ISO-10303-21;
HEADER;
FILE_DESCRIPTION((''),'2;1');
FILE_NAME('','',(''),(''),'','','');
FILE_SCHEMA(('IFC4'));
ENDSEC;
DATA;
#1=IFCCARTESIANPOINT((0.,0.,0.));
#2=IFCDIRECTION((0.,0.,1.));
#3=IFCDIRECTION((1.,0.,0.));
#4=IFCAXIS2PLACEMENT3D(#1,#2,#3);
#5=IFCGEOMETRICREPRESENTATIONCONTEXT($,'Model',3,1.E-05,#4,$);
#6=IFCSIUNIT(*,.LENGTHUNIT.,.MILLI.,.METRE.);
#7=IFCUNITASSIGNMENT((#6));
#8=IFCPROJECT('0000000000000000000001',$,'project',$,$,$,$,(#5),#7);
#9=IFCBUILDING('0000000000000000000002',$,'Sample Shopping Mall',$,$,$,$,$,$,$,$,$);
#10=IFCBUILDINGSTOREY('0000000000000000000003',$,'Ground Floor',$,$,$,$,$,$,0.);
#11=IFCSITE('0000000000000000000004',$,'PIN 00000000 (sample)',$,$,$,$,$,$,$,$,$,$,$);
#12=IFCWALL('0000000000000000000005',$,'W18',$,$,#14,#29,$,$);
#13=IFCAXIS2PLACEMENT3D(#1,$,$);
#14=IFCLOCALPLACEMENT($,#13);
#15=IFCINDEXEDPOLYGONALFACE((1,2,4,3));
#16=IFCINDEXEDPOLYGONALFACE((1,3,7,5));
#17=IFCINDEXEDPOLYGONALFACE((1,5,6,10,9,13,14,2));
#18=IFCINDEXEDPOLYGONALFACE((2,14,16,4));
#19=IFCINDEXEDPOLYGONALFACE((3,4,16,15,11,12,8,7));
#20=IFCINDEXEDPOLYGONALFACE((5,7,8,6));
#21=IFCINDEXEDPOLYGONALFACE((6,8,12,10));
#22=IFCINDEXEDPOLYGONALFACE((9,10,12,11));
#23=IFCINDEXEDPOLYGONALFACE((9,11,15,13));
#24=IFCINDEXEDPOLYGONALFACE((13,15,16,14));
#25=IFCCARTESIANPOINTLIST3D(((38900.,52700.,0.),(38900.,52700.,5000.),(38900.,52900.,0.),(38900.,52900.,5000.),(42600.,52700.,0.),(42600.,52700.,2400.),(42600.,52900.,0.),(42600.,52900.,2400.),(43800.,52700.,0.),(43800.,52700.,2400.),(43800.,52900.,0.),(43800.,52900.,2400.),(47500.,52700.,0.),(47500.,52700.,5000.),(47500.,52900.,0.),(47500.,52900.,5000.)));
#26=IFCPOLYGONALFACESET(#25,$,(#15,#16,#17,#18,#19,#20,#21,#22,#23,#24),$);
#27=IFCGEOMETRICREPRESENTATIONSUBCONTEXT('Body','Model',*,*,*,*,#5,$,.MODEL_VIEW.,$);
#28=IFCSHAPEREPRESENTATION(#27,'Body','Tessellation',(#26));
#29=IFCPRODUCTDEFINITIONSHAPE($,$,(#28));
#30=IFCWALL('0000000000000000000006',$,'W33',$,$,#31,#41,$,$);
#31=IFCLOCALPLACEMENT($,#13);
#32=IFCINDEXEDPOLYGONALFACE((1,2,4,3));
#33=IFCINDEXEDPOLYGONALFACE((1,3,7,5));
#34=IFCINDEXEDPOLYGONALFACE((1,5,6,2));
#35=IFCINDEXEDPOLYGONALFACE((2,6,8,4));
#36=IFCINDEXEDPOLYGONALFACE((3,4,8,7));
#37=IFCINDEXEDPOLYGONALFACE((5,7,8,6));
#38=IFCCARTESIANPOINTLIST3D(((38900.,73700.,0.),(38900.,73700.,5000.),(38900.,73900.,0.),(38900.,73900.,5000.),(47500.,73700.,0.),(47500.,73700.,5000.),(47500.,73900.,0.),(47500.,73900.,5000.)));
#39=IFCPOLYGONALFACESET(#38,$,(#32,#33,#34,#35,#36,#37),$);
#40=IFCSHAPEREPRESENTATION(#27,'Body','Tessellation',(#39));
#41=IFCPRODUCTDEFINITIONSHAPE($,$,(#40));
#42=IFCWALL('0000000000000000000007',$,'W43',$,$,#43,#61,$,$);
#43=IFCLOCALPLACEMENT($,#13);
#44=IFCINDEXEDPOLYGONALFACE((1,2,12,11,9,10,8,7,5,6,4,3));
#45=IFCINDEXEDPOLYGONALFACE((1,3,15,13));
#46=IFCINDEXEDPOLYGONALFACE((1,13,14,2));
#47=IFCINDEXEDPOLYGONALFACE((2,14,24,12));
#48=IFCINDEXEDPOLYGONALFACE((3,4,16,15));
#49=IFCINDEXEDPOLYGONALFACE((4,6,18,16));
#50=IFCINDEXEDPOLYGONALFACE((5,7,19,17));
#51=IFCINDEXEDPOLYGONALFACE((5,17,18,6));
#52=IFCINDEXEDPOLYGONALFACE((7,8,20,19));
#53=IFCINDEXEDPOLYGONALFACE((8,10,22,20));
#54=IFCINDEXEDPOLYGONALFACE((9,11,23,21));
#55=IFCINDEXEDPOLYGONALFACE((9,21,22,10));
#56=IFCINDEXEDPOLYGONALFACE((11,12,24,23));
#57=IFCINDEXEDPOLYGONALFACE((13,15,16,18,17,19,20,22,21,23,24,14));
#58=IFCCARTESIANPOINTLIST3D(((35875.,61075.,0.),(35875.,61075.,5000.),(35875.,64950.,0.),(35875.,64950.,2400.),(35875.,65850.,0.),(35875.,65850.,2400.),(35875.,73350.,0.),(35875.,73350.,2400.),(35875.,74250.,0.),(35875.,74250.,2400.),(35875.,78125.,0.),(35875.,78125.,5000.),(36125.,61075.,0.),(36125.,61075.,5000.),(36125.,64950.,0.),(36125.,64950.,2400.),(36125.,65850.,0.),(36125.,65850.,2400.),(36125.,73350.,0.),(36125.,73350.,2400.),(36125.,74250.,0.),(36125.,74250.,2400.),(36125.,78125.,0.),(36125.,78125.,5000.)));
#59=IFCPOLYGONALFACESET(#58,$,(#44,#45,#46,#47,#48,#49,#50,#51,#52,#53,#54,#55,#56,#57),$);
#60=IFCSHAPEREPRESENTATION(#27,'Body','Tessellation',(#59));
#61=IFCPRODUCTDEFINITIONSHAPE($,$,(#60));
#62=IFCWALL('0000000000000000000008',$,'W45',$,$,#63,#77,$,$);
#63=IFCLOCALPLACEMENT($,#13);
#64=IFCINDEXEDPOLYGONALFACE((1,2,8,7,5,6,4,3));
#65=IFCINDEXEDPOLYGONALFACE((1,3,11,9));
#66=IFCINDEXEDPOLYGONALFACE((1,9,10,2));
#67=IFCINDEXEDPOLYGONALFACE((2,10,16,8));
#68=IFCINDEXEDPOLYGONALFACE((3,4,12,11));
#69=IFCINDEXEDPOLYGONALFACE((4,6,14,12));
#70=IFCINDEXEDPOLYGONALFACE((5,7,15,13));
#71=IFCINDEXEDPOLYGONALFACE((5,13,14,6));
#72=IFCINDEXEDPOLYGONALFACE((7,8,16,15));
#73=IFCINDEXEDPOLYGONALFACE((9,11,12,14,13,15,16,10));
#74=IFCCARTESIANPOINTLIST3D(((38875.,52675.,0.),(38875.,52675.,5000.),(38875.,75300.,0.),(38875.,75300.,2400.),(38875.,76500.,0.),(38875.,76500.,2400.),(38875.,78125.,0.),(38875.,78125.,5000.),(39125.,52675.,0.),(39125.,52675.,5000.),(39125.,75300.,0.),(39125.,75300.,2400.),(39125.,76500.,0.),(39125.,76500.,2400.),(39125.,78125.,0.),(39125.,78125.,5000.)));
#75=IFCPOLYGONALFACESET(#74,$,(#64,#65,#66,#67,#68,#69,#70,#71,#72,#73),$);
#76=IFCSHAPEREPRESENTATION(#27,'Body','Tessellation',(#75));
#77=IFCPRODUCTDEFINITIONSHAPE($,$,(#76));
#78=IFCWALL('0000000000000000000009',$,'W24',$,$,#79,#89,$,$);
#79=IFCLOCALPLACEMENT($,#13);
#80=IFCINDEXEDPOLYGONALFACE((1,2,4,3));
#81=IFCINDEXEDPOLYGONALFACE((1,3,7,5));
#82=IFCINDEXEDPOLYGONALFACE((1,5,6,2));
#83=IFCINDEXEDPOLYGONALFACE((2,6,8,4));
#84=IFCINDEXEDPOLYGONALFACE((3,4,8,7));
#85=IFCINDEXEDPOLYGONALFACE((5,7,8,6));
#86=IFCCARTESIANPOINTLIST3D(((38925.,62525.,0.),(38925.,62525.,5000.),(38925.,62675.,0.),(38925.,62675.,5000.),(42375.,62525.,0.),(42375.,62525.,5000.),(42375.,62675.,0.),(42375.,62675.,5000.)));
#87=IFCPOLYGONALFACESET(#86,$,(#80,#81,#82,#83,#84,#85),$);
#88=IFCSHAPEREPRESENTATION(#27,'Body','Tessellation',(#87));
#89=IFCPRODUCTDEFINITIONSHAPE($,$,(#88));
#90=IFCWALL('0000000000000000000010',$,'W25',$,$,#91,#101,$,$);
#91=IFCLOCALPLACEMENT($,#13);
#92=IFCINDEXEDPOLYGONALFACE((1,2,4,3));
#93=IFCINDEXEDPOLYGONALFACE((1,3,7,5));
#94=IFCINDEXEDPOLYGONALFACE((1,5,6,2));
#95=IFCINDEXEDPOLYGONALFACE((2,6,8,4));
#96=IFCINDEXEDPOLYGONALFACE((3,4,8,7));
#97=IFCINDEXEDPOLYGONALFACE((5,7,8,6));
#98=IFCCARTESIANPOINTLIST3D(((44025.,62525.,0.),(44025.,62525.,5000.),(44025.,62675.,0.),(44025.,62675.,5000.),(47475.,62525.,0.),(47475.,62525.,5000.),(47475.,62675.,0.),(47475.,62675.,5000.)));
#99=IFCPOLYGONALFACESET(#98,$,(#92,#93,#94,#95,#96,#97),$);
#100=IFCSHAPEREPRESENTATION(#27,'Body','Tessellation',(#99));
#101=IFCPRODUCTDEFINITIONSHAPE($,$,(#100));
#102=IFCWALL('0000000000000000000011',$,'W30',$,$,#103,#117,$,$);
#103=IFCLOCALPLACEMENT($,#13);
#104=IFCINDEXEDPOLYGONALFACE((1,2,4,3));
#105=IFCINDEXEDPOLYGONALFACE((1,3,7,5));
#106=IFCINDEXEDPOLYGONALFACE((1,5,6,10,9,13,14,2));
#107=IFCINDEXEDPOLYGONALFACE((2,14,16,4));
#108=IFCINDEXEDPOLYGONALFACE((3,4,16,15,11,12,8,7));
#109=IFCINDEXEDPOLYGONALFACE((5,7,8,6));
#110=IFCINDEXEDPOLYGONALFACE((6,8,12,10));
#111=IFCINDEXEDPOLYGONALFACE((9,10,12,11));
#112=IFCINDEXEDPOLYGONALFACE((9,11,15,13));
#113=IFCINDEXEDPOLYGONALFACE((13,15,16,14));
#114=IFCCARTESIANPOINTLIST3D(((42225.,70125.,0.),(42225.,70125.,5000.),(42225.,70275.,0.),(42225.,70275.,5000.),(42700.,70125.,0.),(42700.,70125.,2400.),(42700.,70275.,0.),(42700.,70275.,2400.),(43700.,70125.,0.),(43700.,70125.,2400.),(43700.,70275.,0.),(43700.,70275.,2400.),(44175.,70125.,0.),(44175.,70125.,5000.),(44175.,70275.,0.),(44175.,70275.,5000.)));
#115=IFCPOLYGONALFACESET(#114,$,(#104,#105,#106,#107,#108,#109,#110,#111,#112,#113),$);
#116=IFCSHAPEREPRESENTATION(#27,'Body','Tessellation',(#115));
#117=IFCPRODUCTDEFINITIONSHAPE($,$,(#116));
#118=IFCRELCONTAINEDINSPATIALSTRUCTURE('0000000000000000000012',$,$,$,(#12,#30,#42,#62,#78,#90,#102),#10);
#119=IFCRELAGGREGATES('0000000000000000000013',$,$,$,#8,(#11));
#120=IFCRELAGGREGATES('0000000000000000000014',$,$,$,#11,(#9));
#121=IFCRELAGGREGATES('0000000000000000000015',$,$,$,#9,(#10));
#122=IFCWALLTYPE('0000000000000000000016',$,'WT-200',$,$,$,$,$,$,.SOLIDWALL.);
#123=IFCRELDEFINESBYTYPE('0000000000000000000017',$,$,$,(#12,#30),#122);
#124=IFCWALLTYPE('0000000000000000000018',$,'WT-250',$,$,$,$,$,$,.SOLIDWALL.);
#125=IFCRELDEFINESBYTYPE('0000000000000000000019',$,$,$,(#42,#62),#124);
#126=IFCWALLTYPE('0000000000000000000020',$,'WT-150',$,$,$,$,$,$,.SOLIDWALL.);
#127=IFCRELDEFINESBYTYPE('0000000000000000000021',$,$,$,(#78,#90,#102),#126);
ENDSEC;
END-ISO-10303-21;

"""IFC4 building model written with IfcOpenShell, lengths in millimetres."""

from ifc_helpers import new_model, si_unit, frame, origin_with_axes, place, context, subcontext, project, spatial, indexed_curve, outline, extrude, type_object, element, save


model = new_model("IFC4")

# Units and contexts
model_context = context("Model", 3, precision=1e-05, world=origin_with_axes())
body_context = subcontext(model_context, "Body", "Model", "MODEL_VIEW")
ifc_project = project(units=[si_unit("LENGTHUNIT", "METRE", prefix="MILLI")], contexts=[model_context])

# Site, building, storey
site = spatial("IfcSite", under=ifc_project, Name="PIN 00000000 (sample)")
building = spatial("IfcBuilding", under=site, Name="Sample Shopping Mall")
storey = spatial("IfcBuildingStorey", under=building, Name="Ground Floor", Elevation=0.0)

# Wall, opening
wall_type_1 = type_object("IfcWallType", Name="WT-200", PredefinedType="SOLIDWALL")
wall_1_placement = place(None, frame((38900.0, 52700.0, 0.0), z_axis=(0.0, 0.0, 1.0), x_axis=(1.0, 0.0, 0.0)))
wall_1 = element("IfcWall", 1, at=wall_1_placement, inside=storey, type_object=wall_type_1, Name="W18", context=body_context, shape_type="SweptSolid", body=[
    extrude(outline(indexed_curve([(0.0, 0.0), (0.0, 200.0), (8600.0, 200.0), (8600.0, 0.0), (0.0, 0.0)], self_intersect=False)), origin_with_axes(), (0.0, 0.0, 1.0), 5000.0),
])
opening_1_placement = place(wall_1_placement, frame((3700.0, -100.0, 0.0), z_axis=(0.0, 0.0, 1.0), x_axis=(1.0, 0.0, 0.0)))
element("IfcOpeningElement", 2, at=opening_1_placement, cuts=wall_1, context=body_context, shape_type="SweptSolid", body=[
    extrude(outline(indexed_curve([(0.0, 0.0), (0.0, 400.0), (1200.0, 400.0), (1200.0, 0.0), (0.0, 0.0)], self_intersect=False)), origin_with_axes(), (0.0, 0.0, 1.0), 2400.0),
])

# Wall
wall_2_placement = place(None, frame((38900.0, 73700.0, 0.0), z_axis=(0.0, 0.0, 1.0), x_axis=(1.0, 0.0, 0.0)))
element("IfcWall", 3, at=wall_2_placement, inside=storey, type_object=wall_type_1, Name="W33", context=body_context, shape_type="SweptSolid", body=[
    extrude(outline(indexed_curve([(0.0, 0.0), (0.0, 200.0), (8600.0, 200.0), (8600.0, 0.0), (0.0, 0.0)], self_intersect=False)), origin_with_axes(), (0.0, 0.0, 1.0), 5000.0),
])

# Wall, openings
wall_type_2 = type_object("IfcWallType", Name="WT-250", PredefinedType="SOLIDWALL")
wall_3_placement = place(None, frame((36125.0, 61075.0, 0.0), z_axis=(0.0, 0.0, 1.0), x_axis=(0.0, 1.0, 0.0)))
wall_3 = element("IfcWall", 4, at=wall_3_placement, inside=storey, type_object=wall_type_2, Name="W43", context=body_context, shape_type="SweptSolid", body=[
    extrude(outline(indexed_curve([(0.0, 0.0), (0.0, 250.0), (17050.0, 250.0), (17050.0, 0.0), (0.0, 0.0)], self_intersect=False)), origin_with_axes(), (0.0, 0.0, 1.0), 5000.0),
])
opening_2_placement = place(wall_3_placement, frame((3875.0, -100.0, 0.0), z_axis=(0.0, 0.0, 1.0), x_axis=(1.0, 0.0, 0.0)))
element("IfcOpeningElement", 5, at=opening_2_placement, cuts=wall_3, context=body_context, shape_type="SweptSolid", body=[
    extrude(outline(indexed_curve([(0.0, 0.0), (0.0, 450.0), (900.0, 450.0), (900.0, 0.0), (0.0, 0.0)], self_intersect=False)), origin_with_axes(), (0.0, 0.0, 1.0), 2400.0),
])
opening_3_placement = place(wall_3_placement, frame((12275.0, -100.0, 0.0), z_axis=(0.0, 0.0, 1.0), x_axis=(1.0, 0.0, 0.0)))
element("IfcOpeningElement", 6, at=opening_3_placement, cuts=wall_3, context=body_context, shape_type="SweptSolid", body=[
    extrude(outline(indexed_curve([(0.0, 0.0), (0.0, 450.0), (900.0, 450.0), (900.0, 0.0), (0.0, 0.0)], self_intersect=False)), origin_with_axes(), (0.0, 0.0, 1.0), 2400.0),
])

# Wall, opening
wall_4_placement = place(None, frame((39125.0, 52675.0, 0.0), z_axis=(0.0, 0.0, 1.0), x_axis=(0.0, 1.0, 0.0)))
wall_4 = element("IfcWall", 7, at=wall_4_placement, inside=storey, type_object=wall_type_2, Name="W45", context=body_context, shape_type="SweptSolid", body=[
    extrude(outline(indexed_curve([(0.0, 0.0), (0.0, 250.0), (25450.0, 250.0), (25450.0, 0.0), (0.0, 0.0)], self_intersect=False)), origin_with_axes(), (0.0, 0.0, 1.0), 5000.0),
])
opening_4_placement = place(wall_4_placement, frame((22625.0, -100.0, 0.0), z_axis=(0.0, 0.0, 1.0), x_axis=(1.0, 0.0, 0.0)))
element("IfcOpeningElement", 8, at=opening_4_placement, cuts=wall_4, context=body_context, shape_type="SweptSolid", body=[
    extrude(outline(indexed_curve([(0.0, 0.0), (0.0, 450.0), (1200.0, 450.0), (1200.0, 0.0), (0.0, 0.0)], self_intersect=False)), origin_with_axes(), (0.0, 0.0, 1.0), 2400.0),
])

# Walls
wall_type_3 = type_object("IfcWallType", Name="WT-150", PredefinedType="SOLIDWALL")
for number, where, z_axis, x_axis, name in (
    (9, (38925.0, 62525.0, 0.0), (0.0, 0.0, 1.0), (1.0, 0.0, 0.0), "W24"),
    (10, (44025.0, 62525.0, 0.0), (0.0, 0.0, 1.0), (1.0, 0.0, 0.0), "W25"),
):
    element("IfcWall", number, at=place(None, frame(where, z_axis=z_axis, x_axis=x_axis)), inside=storey, type_object=wall_type_3, Name=name, context=body_context, shape_type="SweptSolid", body=[
        extrude(outline(indexed_curve([(0.0, 0.0), (0.0, 150.0), (3450.0, 150.0), (3450.0, 0.0), (0.0, 0.0)], self_intersect=False)), origin_with_axes(), (0.0, 0.0, 1.0), 5000.0),
    ])

# Wall, opening
wall_5_placement = place(None, frame((42225.0, 70125.0, 0.0), z_axis=(0.0, 0.0, 1.0), x_axis=(1.0, 0.0, 0.0)))
wall_5 = element("IfcWall", 11, at=wall_5_placement, inside=storey, type_object=wall_type_3, Name="W30", context=body_context, shape_type="SweptSolid", body=[
    extrude(outline(indexed_curve([(0.0, 0.0), (0.0, 150.0), (1950.0, 150.0), (1950.0, 0.0), (0.0, 0.0)], self_intersect=False)), origin_with_axes(), (0.0, 0.0, 1.0), 5000.0),
])
opening_5_placement = place(wall_5_placement, frame((475.0, -100.0, 0.0), z_axis=(0.0, 0.0, 1.0), x_axis=(1.0, 0.0, 0.0)))
element("IfcOpeningElement", 12, at=opening_5_placement, cuts=wall_5, context=body_context, shape_type="SweptSolid", body=[
    extrude(outline(indexed_curve([(0.0, 0.0), (0.0, 350.0), (1000.0, 350.0), (1000.0, 0.0), (0.0, 0.0)], self_intersect=False)), origin_with_axes(), (0.0, 0.0, 1.0), 2400.0),
])

save(model, "model.ifc")
